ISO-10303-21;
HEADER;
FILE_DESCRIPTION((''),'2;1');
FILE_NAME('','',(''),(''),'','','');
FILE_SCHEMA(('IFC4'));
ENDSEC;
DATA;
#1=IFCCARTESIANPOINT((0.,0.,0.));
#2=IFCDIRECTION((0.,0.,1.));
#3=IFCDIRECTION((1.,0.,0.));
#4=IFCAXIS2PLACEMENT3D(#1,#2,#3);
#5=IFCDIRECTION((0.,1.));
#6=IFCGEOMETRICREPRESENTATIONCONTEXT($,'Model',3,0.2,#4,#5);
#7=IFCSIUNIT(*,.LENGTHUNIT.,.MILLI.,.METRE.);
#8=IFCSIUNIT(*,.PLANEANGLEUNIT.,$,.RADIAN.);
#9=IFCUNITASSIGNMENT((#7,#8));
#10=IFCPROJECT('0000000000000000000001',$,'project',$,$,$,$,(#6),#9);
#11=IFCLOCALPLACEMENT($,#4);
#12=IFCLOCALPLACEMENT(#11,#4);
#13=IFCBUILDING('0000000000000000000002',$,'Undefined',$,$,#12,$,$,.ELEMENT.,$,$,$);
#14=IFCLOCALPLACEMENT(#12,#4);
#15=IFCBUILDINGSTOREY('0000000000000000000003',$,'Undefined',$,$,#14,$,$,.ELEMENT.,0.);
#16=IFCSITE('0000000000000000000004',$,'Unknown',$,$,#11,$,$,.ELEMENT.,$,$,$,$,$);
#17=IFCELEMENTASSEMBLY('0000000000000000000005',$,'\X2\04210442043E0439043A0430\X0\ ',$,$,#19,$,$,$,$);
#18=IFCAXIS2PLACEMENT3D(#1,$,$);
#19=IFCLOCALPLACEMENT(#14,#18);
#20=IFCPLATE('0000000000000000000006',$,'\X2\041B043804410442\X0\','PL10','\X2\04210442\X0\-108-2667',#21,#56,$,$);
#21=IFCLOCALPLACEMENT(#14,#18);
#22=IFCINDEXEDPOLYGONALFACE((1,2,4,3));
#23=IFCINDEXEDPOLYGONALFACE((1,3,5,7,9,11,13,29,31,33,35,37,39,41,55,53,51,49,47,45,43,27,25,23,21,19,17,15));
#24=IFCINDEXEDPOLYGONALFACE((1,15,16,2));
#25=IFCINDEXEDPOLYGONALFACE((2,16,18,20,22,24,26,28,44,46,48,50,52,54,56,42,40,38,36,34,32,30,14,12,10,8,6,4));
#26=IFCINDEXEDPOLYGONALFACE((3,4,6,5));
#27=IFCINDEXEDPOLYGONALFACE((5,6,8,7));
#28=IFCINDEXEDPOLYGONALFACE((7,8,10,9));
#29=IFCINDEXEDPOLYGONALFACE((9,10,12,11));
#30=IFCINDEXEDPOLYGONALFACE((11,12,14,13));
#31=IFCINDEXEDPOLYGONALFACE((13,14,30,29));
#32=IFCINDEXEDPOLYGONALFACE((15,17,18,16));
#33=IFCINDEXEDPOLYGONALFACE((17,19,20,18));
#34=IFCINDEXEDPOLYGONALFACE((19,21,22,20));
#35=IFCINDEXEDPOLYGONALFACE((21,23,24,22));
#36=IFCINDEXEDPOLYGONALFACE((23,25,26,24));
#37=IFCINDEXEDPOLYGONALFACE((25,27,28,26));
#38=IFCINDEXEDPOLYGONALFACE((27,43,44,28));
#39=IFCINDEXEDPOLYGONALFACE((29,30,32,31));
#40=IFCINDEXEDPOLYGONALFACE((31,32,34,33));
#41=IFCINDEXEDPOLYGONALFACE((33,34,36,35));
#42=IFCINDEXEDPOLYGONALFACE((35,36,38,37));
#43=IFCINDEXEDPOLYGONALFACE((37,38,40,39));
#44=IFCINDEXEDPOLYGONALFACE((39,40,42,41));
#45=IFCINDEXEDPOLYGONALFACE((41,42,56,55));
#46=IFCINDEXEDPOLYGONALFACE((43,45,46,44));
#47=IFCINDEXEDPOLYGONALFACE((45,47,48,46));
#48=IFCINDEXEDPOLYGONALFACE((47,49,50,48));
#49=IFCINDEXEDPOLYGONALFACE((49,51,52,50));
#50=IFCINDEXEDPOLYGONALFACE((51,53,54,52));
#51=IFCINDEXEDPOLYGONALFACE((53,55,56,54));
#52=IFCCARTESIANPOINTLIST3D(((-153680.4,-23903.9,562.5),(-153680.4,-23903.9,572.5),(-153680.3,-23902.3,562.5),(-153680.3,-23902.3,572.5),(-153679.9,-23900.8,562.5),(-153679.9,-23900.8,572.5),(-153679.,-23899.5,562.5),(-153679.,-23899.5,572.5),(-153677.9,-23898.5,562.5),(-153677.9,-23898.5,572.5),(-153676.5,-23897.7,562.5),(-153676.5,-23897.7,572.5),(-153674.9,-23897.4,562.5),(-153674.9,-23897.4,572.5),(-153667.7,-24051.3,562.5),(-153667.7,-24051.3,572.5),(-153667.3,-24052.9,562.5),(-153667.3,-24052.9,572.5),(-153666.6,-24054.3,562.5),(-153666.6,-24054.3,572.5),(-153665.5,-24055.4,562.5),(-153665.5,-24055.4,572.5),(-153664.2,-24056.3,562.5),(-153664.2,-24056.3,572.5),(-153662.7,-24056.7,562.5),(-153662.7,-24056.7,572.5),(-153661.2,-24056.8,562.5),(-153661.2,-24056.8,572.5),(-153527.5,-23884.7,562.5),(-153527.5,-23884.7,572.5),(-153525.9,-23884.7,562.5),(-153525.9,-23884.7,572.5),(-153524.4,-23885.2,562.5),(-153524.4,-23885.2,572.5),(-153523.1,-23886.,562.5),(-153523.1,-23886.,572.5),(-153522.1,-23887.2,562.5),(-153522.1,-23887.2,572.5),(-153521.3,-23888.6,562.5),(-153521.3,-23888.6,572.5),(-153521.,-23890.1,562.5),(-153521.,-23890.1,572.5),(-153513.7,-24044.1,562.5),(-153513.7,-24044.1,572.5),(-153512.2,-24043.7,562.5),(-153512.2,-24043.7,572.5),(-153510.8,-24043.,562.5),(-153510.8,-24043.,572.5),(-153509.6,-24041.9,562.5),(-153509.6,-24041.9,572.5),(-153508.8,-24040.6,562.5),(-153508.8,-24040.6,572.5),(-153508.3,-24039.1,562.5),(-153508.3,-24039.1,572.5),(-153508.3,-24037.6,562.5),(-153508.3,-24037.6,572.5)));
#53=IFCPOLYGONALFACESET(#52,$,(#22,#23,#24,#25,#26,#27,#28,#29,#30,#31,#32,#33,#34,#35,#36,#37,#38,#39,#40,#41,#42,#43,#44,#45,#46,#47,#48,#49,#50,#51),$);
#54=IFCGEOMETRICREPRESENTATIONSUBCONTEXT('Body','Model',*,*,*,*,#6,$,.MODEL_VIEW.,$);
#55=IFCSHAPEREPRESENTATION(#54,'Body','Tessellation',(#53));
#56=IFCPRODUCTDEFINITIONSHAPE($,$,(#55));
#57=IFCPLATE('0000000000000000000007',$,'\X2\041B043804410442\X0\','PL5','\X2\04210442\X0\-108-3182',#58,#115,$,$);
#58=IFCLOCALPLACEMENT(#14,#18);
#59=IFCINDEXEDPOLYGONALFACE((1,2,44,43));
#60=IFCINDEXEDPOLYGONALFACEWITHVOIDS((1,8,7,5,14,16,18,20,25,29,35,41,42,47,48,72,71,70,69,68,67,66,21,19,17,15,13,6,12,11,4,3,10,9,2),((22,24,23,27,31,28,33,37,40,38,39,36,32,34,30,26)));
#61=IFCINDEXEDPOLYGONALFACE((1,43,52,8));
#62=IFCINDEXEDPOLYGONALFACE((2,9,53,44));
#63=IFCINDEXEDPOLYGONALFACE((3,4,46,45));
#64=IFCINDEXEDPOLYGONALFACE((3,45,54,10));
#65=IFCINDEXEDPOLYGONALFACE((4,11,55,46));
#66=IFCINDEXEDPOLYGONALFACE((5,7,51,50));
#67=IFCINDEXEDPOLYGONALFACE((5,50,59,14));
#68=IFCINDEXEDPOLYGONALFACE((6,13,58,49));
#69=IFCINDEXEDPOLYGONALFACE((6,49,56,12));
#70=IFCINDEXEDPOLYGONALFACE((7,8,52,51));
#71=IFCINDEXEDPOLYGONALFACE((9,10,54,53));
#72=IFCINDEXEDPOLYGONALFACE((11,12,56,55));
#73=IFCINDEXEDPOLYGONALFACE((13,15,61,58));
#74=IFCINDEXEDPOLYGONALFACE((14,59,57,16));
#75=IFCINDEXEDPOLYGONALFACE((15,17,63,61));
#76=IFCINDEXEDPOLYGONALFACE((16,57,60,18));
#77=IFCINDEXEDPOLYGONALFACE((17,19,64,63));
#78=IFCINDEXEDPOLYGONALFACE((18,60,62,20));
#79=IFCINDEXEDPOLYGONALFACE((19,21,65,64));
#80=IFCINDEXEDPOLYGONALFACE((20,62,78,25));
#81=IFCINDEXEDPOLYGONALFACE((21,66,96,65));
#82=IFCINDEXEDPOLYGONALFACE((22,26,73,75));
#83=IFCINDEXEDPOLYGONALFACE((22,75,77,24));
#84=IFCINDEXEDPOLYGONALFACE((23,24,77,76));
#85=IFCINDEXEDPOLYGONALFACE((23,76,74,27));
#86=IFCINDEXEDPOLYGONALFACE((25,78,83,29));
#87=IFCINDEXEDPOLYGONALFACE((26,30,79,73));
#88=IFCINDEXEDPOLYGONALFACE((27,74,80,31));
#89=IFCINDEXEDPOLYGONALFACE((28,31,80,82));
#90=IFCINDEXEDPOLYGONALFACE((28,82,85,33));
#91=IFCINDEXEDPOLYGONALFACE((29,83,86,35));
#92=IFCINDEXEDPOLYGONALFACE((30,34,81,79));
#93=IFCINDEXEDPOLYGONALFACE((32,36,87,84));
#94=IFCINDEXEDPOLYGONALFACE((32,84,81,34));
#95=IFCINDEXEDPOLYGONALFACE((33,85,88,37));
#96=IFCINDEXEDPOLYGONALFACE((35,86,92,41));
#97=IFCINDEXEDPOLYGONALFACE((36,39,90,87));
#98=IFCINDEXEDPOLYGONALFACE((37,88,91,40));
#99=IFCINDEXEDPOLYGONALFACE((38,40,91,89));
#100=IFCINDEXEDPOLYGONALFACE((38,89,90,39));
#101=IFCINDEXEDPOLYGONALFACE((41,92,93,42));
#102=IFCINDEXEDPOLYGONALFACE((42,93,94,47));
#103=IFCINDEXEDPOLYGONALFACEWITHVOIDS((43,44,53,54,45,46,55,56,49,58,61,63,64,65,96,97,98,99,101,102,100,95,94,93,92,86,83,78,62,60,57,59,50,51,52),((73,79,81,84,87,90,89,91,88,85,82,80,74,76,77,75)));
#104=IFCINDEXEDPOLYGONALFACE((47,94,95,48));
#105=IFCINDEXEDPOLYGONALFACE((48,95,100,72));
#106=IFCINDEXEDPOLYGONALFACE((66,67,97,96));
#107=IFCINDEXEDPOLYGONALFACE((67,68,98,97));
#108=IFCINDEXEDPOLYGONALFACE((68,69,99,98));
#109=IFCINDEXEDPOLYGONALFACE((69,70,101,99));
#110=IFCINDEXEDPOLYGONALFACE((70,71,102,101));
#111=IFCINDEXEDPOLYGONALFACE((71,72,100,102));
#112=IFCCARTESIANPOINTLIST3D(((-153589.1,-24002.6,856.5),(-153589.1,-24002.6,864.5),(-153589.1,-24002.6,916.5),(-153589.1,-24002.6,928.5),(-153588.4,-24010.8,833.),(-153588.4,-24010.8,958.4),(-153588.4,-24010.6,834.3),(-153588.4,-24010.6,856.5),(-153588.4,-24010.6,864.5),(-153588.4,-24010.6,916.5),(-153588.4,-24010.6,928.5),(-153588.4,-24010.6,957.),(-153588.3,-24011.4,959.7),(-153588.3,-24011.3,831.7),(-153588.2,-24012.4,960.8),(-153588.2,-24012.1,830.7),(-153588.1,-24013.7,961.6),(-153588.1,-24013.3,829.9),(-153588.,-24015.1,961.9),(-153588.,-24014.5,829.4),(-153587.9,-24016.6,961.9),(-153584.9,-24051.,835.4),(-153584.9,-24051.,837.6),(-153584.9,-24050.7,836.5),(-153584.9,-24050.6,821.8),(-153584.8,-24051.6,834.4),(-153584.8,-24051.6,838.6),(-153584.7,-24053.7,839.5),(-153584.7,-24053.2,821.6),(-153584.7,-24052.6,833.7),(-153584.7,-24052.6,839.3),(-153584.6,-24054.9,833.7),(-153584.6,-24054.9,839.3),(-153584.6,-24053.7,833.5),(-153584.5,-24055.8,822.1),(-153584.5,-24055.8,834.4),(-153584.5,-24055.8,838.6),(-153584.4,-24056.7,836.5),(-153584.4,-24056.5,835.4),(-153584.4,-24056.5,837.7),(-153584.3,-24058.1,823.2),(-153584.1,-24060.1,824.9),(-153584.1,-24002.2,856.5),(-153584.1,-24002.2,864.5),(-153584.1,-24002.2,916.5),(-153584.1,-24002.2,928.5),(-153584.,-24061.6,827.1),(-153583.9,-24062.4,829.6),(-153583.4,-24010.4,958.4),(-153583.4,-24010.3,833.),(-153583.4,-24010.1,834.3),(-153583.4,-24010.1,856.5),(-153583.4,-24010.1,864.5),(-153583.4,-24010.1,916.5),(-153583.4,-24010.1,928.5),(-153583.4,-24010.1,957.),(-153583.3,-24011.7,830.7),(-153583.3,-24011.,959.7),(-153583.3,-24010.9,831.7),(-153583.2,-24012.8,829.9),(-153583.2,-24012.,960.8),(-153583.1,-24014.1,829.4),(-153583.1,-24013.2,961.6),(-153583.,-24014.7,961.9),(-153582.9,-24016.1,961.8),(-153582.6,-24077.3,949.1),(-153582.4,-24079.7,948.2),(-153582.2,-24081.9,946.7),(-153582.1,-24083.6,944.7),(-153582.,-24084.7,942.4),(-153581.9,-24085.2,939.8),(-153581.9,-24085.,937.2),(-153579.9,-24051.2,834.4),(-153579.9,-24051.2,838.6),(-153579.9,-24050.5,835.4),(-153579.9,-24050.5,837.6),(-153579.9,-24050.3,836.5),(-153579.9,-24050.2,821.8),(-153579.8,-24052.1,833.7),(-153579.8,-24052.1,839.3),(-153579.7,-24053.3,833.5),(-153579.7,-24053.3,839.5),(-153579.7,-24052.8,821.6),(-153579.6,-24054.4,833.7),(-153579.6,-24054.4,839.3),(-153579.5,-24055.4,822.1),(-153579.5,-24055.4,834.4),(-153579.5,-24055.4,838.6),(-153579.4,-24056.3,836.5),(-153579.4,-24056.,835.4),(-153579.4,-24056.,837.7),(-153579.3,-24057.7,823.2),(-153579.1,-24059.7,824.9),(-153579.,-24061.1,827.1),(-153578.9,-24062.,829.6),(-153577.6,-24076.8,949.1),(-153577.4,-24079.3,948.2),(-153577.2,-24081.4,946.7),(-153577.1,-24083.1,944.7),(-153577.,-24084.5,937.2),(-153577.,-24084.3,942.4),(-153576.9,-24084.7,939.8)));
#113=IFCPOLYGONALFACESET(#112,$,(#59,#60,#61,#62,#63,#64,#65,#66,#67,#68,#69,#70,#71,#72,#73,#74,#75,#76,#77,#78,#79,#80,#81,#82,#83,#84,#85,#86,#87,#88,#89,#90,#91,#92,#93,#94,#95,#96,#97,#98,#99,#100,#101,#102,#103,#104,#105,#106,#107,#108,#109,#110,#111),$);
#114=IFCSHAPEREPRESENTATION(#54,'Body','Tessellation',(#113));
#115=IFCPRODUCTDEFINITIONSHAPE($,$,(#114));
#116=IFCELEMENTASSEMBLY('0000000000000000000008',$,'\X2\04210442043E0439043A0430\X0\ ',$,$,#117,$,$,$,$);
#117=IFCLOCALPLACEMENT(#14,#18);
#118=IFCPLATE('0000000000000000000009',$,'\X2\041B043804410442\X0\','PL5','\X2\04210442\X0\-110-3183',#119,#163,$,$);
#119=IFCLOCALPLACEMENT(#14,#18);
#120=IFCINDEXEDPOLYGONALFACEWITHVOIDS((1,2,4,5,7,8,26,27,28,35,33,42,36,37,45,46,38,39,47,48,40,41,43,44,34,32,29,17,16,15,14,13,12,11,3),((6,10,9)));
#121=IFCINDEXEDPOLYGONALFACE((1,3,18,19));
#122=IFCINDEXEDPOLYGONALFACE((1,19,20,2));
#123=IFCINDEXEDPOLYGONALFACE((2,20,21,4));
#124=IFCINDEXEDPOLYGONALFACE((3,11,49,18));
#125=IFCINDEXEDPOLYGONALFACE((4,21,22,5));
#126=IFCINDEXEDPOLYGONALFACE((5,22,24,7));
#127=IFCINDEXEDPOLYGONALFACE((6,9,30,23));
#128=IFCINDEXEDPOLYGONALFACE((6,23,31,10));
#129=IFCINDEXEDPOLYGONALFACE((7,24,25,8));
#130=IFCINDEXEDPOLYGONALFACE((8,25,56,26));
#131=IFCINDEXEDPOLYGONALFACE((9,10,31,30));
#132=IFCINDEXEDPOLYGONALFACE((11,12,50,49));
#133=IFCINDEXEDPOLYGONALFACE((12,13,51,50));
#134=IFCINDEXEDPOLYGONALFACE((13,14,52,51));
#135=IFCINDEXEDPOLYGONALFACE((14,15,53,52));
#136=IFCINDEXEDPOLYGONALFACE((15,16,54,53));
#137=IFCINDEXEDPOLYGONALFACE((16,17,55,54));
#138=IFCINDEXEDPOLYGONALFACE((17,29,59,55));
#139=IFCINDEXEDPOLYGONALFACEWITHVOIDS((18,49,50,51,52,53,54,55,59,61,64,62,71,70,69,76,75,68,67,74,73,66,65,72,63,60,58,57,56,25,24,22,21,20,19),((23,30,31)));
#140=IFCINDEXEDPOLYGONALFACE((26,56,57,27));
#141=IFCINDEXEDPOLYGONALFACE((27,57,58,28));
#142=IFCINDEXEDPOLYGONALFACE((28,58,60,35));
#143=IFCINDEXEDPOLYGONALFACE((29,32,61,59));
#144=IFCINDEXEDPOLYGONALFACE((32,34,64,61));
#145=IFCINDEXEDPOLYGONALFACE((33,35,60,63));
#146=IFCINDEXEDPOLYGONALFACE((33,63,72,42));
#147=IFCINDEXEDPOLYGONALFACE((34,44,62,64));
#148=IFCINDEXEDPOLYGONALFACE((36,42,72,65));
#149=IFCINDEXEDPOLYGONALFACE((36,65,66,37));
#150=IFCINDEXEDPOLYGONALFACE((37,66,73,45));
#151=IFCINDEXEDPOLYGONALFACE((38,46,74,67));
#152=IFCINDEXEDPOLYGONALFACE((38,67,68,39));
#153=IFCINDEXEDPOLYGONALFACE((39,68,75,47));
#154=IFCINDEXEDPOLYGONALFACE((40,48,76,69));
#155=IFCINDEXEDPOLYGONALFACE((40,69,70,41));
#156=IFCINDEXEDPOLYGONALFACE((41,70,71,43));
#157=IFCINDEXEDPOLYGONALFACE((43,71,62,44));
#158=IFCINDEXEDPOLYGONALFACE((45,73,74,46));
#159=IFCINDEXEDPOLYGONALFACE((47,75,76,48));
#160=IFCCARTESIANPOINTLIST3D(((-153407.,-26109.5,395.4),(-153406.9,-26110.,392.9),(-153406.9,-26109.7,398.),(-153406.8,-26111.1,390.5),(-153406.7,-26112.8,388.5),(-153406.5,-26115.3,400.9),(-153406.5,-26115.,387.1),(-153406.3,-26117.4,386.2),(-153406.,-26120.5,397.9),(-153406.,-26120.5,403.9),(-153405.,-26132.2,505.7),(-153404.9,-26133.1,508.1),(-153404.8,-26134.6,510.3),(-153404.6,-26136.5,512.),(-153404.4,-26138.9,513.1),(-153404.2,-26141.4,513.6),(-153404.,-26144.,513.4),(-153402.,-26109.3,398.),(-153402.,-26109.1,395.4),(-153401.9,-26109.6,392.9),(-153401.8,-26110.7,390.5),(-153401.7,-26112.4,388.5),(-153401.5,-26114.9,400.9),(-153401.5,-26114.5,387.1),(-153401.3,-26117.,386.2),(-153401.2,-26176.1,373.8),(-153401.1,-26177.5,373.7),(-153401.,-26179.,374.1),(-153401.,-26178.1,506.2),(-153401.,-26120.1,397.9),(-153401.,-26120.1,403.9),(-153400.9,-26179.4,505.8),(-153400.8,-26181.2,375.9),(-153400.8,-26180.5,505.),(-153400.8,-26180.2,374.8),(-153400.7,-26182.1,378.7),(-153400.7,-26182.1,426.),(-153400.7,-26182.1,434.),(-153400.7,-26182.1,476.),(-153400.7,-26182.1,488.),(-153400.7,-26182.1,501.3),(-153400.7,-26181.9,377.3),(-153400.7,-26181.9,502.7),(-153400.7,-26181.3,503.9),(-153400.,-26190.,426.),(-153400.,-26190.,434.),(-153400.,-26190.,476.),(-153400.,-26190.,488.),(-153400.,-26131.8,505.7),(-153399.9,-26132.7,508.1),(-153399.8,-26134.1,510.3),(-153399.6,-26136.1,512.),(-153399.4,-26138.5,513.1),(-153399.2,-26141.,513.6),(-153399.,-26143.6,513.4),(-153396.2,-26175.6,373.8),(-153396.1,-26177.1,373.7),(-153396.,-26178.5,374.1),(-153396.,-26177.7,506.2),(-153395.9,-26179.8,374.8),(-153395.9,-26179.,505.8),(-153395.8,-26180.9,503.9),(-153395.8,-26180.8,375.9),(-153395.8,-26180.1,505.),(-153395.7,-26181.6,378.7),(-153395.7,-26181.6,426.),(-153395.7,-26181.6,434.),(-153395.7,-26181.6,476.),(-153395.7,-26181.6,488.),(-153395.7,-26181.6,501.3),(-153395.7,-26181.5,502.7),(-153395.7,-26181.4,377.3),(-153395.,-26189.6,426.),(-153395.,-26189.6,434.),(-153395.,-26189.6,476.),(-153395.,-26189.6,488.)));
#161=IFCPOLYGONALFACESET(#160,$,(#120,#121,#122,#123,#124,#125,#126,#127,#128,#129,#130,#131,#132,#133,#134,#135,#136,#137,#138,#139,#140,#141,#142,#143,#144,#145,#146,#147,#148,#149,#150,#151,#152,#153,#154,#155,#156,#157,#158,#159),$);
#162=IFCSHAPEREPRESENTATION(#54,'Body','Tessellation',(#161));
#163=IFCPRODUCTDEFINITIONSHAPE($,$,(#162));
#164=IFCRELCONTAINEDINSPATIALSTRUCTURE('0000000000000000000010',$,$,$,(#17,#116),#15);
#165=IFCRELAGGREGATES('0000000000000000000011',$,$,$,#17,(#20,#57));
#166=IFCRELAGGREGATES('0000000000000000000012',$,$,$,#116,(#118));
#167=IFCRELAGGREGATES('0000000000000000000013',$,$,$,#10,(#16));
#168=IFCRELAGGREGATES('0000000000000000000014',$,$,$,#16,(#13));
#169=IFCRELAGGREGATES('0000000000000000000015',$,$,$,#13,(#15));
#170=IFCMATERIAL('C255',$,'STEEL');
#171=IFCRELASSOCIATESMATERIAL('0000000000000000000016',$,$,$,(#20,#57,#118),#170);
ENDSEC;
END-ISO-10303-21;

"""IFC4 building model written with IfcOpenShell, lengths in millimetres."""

from ifc_helpers import new_model, si_unit, direction, frame, origin_with_axes, place, context, subcontext, project, spatial, line, arc, indexed_curve, outline, extrude, material, element, aggregate, save


model = new_model("IFC4")

# Units and contexts
model_context = context("Model", 3, precision=0.2, world=origin_with_axes(), true_north=direction((0.0, 1.0)))
body_context = subcontext(model_context, "Body", "Model", "MODEL_VIEW")
ifc_project = project(units=[si_unit("LENGTHUNIT", "METRE", prefix="MILLI"), si_unit("PLANEANGLEUNIT", "RADIAN")], contexts=[model_context])

# Site, building, storey
site_placement = place(None, origin_with_axes())
site = spatial("IfcSite", under=ifc_project, at=site_placement, Name="Unknown", CompositionType="ELEMENT")
building_placement = place(site_placement, origin_with_axes())
building = spatial("IfcBuilding", under=site, at=building_placement, Name="Undefined", CompositionType="ELEMENT")
storey_placement = place(building_placement, origin_with_axes())
storey = spatial("IfcBuildingStorey", under=building, at=storey_placement, Name="Undefined", CompositionType="ELEMENT", Elevation=0.0)

# Element assemblies, plates, voiding features
assembly_1_placement = place(storey_placement, frame((-153594.3, -23970.7, 698.5), z_axis=(-0.086114, 0.996285, 0.0), x_axis=(0.0, 0.0, 1.0)))
assembly_1 = element("IfcElementAssembly", 1, at=assembly_1_placement, inside=storey, Name="Стойка ")
ifc_material_1 = material(Name="C255", Category="STEEL")
plate_1_placement = place(assembly_1_placement, frame((-131.0, 80.0, -80.0), z_axis=(1.0, 0.0, 0.0), x_axis=(0.0, 0.0, 1.0)))
plate_1 = element("IfcPlate", 2, at=plate_1_placement, material=ifc_material_1, Name="Лист", Description="PL10", ObjectType="Ст-108-2667", context=body_context, shape_type="SolidModel", body=[
    extrude(outline(indexed_curve([(0.0, 6.0), (1.8, 1.8), (6.0, 0.0), (154.0, 0.0), (158.2, 1.8), (160.0, 6.0), (160.0, 154.0), (158.2, 158.2), (154.0, 160.0), (6.0, 160.0), (1.8, 158.2), (0.0, 154.0)], segments=[arc(1, 2, 3), line(3, 4), arc(4, 5, 6), line(6, 7), arc(7, 8, 9), line(9, 10), arc(10, 11, 12), line(12, 1)])), frame((0.0, 0.0, 5.0), z_axis=(0.0, 0.0, 1.0), x_axis=(1.0, 0.0, 0.0)), (0.0, 0.0, -1.0), 10.0),
])
plate_2_placement = place(assembly_1_placement, frame((121.2, 5.0, -90.2), z_axis=(0.000024, -1.0, -0.000005), x_axis=(0.978653, 0.000024, -0.205517)))
plate_2 = element("IfcPlate", 3, at=plate_2_placement, material=ifc_material_1, Name="Лист", Description="PL5", ObjectType="Ст-108-3182", context=body_context, shape_type="SolidModel", body=[
    extrude(outline(indexed_curve([(0.0, 10.0), (2.9, 2.9), (10.0, 0.0), (120.0, 0.0), (127.1, 2.9), (130.0, 10.0), (130.0, 72.2), (128.2, 76.1), (124.0, 77.1), (96.1, 71.3), (94.5, 79.1), (82.7, 76.7), (84.4, 68.8), (33.5, 58.1), (31.8, 66.0), (24.0, 64.3), (25.7, 56.5), (4.0, 51.9), (1.1, 50.2), (0.0, 47.0)], segments=[arc(1, 2, 3), line(3, 4), arc(4, 5, 6), line(6, 7), arc(7, 8, 9), line(9, 10, 11, 12, 13, 14, 15, 16, 17, 18), arc(18, 19, 20), line(20, 1)])), frame((0.0, 0.0, 2.5), z_axis=(0.0, 0.0, 1.0), x_axis=(1.0, 0.0, 0.0)), (0.0, 0.0, -1.0), 5.0),
])
voiding_feature_1_placement = place(plate_2_placement, frame((15.0, 10.0, 10.0), z_axis=(0.208475, -0.978028, 0.0), x_axis=(0.0, 0.0, -1.0)))
element("IfcVoidingFeature", 4, at=voiding_feature_1_placement, cuts=plate_2, Name="Балка", ObjectType="(?)", PredefinedType="HOLE", context=body_context, shape_type="SolidModel", body=[
    extrude(outline(indexed_curve([(3.0, 0.0), (2.8, 1.1), (2.1, 2.1), (1.1, 2.8), (0.0, 3.0), (-1.1, 2.8), (-2.1, 2.1), (-2.8, 1.1), (-3.0, 0.0), (-2.8, -1.1), (-2.1, -2.1), (-1.1, -2.8), (0.0, -3.0), (1.1, -2.8), (2.1, -2.1), (2.8, -1.1)], segments=[line(1, 2, 3, 4, 5, 6, 7, 8, 9, 10, 11, 12, 13, 14, 15, 16, 1)])), frame((0.0, 0.0, 0.0), z_axis=(-1.0, 0.0, 0.0), x_axis=(0.0, 0.0, 1.0)), (0.0, 0.0, -1.0), 20.0),
])
assembly_2_placement = place(storey_placement, frame((-153388.9, -26231.4, 131.5), z_axis=(-0.086114, 0.996285, 0.0), x_axis=(0.0, 0.0, 1.0)))
assembly_2 = element("IfcElementAssembly", 5, at=assembly_2_placement, inside=storey, Name="Стойка ")
plate_3_placement = place(assembly_2_placement, frame((256.7, -5.0, 124.9), z_axis=(-0.000024, 1.0, 0.0), x_axis=(0.978653, 0.000024, -0.205517)))
plate_3 = element("IfcPlate", 6, at=plate_3_placement, material=ifc_material_1, Name="Лист", Description="PL5", ObjectType="Ст-110-3183", context=body_context, shape_type="SolidModel", body=[
    extrude(outline(indexed_curve([(0.0, 10.0), (2.9, 2.9), (10.0, 0.0), (120.0, 0.0), (127.1, 2.9), (130.0, 10.0), (130.0, 44.9), (128.9, 48.1), (126.0, 49.8), (113.0, 52.6), (114.6, 60.4), (102.9, 62.9), (101.2, 55.0), (60.1, 63.7), (61.8, 71.5), (53.9, 73.2), (52.3, 65.3), (6.0, 75.0), (1.8, 74.0), (0.0, 70.1)], segments=[arc(1, 2, 3), line(3, 4), arc(4, 5, 6), line(6, 7), arc(7, 8, 9), line(9, 10, 11, 12, 13, 14, 15, 16, 17, 18), arc(18, 19, 20), line(20, 1)])), frame((0.0, 0.0, 2.5), z_axis=(0.0, 0.0, 1.0), x_axis=(1.0, 0.0, 0.0)), (0.0, 0.0, -1.0), 5.0),
])
voiding_feature_2_placement = place(plate_3_placement, frame((15.0, 10.0, 10.0), z_axis=(-0.202559, -0.97927, 0.0), x_axis=(0.0, 0.0, -1.0)))
element("IfcVoidingFeature", 7, at=voiding_feature_2_placement, cuts=plate_3, Name="Балка", ObjectType="(?)", PredefinedType="HOLE", context=body_context, shape_type="SolidModel", body=[
    extrude(outline(indexed_curve([(0.0, -3.0), (5.2, 0.0), (0.0, 3.0)], segments=[line(1, 2, 3, 1)])), frame((0.0, 0.0, 0.0), z_axis=(-1.0, 0.0, 0.0), x_axis=(0.0, 0.0, 1.0)), (0.0, 0.0, -1.0), 20.0),
])

aggregate(assembly_1, [plate_1, plate_2])
aggregate(assembly_2, [plate_3])

save(model, "model.ifc")
